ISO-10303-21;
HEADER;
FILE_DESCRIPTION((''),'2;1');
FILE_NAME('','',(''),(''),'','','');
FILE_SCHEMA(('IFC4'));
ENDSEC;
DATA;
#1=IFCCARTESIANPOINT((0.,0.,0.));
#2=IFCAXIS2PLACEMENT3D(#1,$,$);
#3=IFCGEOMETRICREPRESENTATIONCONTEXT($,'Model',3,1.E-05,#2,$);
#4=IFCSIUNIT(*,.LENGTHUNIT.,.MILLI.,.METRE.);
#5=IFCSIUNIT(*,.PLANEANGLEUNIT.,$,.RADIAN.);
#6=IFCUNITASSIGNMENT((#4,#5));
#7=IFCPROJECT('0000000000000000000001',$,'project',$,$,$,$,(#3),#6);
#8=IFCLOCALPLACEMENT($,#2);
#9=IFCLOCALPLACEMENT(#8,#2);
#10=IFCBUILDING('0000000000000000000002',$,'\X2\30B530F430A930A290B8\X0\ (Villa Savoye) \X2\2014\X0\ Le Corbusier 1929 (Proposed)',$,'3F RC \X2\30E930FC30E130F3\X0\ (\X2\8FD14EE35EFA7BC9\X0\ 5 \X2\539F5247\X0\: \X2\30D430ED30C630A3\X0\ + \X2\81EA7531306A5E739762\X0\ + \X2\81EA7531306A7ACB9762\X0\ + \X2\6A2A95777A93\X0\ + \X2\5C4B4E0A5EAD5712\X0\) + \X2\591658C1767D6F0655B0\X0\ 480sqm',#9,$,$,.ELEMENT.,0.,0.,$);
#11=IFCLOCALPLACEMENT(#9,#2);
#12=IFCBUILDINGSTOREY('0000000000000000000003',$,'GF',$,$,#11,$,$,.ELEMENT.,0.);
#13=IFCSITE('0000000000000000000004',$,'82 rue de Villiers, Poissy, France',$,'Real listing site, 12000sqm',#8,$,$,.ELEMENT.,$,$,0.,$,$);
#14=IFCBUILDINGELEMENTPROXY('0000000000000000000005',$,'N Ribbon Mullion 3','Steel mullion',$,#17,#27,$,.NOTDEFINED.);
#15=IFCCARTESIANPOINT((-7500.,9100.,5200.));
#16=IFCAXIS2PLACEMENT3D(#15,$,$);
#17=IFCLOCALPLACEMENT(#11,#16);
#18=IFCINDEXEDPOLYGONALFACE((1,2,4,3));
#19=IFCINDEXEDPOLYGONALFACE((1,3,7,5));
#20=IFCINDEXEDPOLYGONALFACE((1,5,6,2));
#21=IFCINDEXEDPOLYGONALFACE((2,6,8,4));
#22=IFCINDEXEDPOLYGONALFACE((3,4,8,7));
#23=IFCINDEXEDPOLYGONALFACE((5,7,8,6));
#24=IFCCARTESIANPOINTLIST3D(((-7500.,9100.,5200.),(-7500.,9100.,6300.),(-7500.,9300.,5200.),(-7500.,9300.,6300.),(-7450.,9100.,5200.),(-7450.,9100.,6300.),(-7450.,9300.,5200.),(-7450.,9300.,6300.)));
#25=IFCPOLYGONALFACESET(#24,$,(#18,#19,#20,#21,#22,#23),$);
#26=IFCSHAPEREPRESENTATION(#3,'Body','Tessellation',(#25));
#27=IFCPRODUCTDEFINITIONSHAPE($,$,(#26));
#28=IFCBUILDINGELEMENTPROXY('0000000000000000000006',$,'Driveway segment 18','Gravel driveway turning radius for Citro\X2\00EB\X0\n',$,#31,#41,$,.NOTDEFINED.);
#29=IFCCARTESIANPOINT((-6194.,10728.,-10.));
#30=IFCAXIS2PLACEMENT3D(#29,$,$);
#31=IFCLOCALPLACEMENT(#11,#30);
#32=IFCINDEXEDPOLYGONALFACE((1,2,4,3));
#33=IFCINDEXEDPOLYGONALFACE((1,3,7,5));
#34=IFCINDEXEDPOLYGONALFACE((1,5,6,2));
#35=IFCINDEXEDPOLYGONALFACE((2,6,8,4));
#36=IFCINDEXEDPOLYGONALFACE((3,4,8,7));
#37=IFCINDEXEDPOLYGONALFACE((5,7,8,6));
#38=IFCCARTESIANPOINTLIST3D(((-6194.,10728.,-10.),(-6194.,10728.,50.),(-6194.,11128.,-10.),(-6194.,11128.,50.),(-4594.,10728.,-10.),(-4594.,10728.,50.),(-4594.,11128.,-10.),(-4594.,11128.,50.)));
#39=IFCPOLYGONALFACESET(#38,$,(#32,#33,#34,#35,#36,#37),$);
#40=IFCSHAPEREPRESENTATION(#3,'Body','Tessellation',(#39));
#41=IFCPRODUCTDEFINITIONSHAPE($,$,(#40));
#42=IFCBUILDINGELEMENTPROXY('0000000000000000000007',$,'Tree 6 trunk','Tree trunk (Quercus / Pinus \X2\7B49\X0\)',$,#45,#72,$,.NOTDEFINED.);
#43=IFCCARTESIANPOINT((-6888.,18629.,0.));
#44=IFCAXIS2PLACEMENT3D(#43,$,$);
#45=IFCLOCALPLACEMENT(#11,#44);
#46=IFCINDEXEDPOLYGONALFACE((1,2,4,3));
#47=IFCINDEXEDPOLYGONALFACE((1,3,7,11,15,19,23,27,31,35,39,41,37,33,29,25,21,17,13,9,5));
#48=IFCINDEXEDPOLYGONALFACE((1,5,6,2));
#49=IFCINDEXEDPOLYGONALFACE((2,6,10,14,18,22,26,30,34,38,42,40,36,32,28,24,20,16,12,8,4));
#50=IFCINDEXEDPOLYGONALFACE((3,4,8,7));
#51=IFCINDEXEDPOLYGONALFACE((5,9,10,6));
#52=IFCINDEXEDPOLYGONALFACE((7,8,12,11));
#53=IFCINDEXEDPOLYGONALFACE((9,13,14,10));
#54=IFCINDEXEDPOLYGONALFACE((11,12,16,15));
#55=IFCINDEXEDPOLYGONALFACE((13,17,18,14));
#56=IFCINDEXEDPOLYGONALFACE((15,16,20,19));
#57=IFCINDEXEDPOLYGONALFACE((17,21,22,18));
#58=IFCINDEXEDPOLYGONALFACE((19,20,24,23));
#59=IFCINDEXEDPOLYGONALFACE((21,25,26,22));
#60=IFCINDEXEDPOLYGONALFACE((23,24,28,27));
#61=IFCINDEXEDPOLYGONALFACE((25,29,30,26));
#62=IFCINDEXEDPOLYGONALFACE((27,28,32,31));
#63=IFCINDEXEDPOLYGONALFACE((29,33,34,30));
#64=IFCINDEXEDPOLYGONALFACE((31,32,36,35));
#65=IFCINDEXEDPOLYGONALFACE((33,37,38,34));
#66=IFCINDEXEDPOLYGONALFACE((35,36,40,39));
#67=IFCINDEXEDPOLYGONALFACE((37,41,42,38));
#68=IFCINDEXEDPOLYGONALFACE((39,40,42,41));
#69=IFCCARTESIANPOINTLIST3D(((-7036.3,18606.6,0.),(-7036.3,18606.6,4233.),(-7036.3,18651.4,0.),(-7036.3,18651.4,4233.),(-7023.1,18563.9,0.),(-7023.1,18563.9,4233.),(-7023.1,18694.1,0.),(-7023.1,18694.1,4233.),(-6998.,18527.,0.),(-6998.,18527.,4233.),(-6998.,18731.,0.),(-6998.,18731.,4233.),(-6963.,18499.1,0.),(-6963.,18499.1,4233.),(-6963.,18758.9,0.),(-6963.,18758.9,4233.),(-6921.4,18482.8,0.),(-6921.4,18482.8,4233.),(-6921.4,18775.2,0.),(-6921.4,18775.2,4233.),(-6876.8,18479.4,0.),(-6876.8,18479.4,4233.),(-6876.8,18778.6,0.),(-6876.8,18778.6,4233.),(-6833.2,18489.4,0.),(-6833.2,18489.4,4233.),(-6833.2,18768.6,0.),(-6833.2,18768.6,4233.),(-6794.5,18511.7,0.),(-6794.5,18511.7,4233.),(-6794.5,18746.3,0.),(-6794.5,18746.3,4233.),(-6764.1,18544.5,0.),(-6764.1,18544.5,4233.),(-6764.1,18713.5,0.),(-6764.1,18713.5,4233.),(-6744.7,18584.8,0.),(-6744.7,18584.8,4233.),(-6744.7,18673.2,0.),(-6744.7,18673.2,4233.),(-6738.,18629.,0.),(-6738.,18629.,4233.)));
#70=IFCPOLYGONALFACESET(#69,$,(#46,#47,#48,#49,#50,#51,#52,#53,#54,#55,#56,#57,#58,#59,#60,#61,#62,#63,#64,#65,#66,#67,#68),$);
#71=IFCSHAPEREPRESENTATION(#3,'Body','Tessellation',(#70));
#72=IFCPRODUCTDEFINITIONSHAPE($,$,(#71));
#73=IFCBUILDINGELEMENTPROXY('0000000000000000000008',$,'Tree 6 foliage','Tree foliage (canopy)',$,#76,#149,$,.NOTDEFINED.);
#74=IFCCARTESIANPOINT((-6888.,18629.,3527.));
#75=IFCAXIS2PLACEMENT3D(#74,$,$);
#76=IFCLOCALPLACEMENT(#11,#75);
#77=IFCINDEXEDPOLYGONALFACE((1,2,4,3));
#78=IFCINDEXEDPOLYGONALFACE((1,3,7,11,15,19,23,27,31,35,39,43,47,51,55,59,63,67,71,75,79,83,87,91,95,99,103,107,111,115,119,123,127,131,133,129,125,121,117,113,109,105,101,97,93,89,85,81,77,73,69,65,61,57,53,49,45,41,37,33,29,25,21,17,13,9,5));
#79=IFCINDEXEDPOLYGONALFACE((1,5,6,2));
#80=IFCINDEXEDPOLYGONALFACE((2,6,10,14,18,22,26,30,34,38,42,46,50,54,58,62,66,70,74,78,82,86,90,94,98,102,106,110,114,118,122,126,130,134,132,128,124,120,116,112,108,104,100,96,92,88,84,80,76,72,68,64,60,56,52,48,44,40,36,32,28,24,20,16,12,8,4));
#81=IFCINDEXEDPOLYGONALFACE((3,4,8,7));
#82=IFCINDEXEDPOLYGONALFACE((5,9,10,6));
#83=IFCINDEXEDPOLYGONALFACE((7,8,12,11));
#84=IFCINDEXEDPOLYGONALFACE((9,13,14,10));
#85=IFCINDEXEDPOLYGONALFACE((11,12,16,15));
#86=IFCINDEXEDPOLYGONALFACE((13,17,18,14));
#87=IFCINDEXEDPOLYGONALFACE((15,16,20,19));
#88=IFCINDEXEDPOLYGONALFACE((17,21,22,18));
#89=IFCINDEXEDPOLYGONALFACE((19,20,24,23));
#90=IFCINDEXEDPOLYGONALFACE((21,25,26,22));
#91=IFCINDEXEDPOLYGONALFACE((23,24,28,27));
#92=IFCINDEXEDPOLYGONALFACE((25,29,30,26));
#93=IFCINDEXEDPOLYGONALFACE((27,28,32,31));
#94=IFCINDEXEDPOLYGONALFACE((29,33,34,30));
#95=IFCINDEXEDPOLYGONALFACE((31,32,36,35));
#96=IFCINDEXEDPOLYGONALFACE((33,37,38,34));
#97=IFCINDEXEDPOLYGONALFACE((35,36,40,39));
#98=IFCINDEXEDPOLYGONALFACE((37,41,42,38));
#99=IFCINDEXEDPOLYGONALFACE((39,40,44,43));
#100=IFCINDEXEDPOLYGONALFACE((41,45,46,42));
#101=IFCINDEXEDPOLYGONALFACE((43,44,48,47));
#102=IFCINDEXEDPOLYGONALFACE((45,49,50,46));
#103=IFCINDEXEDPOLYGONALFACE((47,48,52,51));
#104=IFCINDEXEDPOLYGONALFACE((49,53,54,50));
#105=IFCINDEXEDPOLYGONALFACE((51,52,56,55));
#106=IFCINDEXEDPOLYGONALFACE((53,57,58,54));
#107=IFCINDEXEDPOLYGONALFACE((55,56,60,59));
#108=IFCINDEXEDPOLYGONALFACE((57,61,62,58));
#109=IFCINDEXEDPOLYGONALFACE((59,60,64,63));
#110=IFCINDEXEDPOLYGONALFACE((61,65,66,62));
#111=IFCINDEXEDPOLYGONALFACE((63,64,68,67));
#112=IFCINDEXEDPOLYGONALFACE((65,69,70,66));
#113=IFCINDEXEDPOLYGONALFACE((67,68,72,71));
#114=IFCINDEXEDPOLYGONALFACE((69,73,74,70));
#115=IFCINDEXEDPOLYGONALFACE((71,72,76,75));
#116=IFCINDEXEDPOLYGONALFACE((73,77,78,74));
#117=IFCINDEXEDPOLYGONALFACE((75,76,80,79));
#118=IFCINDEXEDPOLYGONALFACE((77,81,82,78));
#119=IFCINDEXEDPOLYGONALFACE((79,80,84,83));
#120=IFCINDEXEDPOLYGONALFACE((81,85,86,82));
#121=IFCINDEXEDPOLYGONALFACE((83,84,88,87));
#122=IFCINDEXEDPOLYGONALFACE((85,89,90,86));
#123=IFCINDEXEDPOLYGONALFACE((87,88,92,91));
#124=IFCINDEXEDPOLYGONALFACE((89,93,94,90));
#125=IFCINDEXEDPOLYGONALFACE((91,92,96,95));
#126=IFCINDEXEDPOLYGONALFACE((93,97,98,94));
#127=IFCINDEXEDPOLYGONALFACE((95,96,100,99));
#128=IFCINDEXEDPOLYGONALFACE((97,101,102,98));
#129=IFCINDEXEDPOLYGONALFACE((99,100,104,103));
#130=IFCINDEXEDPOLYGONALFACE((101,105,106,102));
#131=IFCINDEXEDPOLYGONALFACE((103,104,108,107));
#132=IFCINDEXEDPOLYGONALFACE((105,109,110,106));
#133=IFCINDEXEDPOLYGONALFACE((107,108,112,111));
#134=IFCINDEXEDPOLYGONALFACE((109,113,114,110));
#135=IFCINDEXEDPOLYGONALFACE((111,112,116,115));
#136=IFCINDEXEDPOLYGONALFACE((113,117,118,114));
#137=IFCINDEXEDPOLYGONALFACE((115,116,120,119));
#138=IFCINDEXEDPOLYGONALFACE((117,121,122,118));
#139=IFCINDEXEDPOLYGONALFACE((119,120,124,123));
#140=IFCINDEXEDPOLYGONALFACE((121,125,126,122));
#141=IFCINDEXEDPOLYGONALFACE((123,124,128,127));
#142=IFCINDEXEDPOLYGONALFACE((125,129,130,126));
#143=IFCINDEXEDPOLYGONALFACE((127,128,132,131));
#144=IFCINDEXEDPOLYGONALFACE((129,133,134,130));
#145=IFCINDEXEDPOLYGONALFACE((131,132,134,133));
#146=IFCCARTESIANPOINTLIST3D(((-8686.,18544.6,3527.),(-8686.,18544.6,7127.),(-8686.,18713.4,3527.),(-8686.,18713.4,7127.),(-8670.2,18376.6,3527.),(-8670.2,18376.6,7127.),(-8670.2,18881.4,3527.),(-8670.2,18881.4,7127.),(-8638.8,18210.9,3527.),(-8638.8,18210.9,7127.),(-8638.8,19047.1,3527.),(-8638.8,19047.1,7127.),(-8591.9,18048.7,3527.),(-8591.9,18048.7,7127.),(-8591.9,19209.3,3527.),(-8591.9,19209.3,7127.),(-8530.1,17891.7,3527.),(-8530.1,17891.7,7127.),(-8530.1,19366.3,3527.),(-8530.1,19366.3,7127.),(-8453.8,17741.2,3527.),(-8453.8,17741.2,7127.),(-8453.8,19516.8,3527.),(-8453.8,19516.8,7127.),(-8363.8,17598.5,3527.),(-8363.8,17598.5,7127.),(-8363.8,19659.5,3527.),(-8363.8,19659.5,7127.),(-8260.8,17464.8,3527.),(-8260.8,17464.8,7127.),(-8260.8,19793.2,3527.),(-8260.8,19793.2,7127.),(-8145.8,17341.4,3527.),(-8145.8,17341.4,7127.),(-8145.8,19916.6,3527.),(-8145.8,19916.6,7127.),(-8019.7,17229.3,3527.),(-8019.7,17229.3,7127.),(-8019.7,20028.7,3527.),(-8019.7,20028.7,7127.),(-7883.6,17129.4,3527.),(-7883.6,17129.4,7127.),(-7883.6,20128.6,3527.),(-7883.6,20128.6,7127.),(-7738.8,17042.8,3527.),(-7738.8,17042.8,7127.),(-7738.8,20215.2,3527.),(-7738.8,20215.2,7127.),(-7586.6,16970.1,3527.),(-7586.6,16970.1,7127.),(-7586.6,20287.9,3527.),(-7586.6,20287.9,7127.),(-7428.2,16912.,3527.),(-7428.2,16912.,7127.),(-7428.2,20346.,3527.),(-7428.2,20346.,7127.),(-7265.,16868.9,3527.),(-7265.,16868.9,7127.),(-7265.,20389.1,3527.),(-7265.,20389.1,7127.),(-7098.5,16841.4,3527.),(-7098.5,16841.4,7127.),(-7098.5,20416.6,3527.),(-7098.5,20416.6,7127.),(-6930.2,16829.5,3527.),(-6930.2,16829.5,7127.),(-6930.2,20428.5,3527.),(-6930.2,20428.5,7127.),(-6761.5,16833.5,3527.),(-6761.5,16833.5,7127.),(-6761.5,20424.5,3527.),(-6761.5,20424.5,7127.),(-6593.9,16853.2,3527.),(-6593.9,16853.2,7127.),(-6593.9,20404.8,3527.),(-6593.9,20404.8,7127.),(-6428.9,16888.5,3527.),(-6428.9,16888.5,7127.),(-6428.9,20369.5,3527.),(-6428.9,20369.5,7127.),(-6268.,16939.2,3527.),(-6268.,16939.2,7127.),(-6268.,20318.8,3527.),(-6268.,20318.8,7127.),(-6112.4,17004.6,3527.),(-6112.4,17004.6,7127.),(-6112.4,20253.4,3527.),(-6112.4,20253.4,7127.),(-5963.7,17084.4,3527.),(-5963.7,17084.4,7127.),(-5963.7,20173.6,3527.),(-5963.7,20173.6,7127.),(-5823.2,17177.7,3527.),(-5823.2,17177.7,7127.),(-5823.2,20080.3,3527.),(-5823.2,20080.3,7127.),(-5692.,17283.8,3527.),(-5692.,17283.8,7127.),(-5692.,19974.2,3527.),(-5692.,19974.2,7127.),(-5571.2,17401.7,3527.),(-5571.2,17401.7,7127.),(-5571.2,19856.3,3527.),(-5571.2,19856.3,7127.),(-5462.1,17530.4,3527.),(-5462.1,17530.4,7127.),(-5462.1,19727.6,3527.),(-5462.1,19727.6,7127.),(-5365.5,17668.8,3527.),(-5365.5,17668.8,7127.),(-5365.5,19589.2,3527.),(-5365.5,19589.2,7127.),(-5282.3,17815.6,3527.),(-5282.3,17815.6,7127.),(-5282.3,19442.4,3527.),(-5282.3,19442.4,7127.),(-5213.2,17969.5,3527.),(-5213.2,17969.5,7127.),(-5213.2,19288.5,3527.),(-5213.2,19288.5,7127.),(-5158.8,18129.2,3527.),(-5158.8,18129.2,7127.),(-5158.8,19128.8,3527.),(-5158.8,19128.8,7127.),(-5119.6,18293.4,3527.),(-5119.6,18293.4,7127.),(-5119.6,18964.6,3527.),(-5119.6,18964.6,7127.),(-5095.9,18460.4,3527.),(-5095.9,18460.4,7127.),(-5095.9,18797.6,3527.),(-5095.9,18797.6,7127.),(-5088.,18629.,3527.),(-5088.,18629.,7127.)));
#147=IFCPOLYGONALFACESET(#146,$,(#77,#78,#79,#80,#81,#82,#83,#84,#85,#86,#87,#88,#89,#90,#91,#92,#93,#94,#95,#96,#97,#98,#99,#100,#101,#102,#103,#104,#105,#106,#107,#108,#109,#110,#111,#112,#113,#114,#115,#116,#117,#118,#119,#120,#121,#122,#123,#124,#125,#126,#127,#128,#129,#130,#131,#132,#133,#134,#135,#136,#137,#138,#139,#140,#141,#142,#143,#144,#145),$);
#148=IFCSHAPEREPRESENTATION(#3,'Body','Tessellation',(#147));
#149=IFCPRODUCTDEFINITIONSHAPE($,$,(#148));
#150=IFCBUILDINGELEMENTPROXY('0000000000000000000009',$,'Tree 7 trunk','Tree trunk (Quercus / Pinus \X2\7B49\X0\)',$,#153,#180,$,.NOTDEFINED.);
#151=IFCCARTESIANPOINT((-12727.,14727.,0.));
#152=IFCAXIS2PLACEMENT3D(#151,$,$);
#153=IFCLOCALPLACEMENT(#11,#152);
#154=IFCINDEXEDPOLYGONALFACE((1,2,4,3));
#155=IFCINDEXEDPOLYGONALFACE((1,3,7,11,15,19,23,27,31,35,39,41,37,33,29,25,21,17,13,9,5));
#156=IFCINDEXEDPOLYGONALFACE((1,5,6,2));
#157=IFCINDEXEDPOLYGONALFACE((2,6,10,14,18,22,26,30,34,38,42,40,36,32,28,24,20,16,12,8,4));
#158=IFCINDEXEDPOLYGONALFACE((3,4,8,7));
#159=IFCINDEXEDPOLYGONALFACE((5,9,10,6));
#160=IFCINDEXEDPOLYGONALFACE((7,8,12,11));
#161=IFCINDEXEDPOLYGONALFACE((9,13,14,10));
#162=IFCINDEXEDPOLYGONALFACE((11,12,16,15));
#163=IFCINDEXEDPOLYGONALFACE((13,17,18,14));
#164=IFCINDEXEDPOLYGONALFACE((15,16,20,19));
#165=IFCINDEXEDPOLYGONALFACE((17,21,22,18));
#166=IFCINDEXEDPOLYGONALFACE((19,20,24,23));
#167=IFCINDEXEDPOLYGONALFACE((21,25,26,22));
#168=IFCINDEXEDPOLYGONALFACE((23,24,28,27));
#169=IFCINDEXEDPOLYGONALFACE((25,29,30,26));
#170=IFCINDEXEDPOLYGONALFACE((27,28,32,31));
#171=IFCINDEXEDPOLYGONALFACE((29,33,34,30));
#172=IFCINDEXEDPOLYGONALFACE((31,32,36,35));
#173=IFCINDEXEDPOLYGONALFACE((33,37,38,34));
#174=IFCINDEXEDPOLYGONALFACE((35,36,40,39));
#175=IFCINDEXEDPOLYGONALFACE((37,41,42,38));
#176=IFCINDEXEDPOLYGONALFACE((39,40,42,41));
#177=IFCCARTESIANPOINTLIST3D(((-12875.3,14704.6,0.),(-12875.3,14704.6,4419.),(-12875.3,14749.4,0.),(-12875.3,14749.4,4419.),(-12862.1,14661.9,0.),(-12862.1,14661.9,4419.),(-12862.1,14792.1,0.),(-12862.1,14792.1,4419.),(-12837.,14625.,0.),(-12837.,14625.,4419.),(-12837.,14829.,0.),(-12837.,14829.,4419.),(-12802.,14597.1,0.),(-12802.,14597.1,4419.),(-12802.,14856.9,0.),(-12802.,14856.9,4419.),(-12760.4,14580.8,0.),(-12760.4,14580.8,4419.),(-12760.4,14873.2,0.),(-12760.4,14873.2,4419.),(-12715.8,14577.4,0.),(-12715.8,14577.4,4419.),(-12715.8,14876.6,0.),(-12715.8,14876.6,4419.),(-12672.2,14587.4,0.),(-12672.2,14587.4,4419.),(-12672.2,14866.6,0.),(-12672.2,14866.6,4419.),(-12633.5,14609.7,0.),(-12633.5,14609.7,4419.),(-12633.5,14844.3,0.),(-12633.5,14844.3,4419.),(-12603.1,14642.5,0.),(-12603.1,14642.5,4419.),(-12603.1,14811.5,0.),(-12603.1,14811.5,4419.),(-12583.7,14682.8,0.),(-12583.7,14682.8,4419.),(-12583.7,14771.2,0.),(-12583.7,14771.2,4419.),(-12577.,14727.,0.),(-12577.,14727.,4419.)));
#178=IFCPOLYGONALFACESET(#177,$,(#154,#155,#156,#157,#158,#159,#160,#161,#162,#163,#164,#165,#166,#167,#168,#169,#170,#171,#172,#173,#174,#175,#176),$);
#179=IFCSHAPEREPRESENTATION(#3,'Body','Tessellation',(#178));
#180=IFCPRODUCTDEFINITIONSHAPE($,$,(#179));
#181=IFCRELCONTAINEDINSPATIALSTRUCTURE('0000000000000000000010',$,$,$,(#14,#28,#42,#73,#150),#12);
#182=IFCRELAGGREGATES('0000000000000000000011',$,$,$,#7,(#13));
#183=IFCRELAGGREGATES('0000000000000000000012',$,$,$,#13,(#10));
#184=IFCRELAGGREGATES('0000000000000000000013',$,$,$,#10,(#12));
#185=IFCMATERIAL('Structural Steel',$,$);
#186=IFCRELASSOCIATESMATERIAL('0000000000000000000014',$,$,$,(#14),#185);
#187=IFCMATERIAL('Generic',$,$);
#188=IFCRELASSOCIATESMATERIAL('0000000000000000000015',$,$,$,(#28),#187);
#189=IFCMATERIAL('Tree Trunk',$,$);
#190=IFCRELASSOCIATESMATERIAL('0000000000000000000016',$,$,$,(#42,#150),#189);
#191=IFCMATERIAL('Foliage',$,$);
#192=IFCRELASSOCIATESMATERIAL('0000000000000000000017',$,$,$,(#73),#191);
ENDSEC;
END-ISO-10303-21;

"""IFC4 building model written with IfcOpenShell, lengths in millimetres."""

from ifc_helpers import new_model, si_unit, frame, frame_2d, origin, origin_2d, place, context, project, spatial, rectangle, circle, extrude, material, element, save


model = new_model("IFC4")

# Units and contexts
model_context = context("Model", 3, precision=1e-05, world=origin())
ifc_project = project(units=[si_unit("LENGTHUNIT", "METRE", prefix="MILLI"), si_unit("PLANEANGLEUNIT", "RADIAN")], contexts=[model_context])

# Site, building, storey
site_placement = place(None, origin())
site = spatial("IfcSite", under=ifc_project, at=site_placement, Name="82 rue de Villiers, Poissy, France", ObjectType="Real listing site, 12000sqm", CompositionType="ELEMENT", RefElevation=0.0)
building_placement = place(site_placement, origin())
building = spatial("IfcBuilding", under=site, at=building_placement, Name="サヴォア邸 (Villa Savoye) — Le Corbusier 1929 (Proposed)", ObjectType="3F RC ラーメン (近代建築 5 原則: ピロティ + 自由な平面 + 自由な立面 + 横長窓 + 屋上庭園) + 外壁白漆喰 480sqm", CompositionType="ELEMENT", ElevationOfRefHeight=0.0, ElevationOfTerrain=0.0)
storey_placement = place(building_placement, origin())
storey = spatial("IfcBuildingStorey", under=building, at=storey_placement, Name="GF", CompositionType="ELEMENT", Elevation=0.0)

# Shared definitions
ifc_material_1 = material(Name="Generic")

# Building element proxies
ifc_material_2 = material(Name="Structural Steel")
proxy_1_placement = place(storey_placement, frame((-7500.0, 9100.0, 5200.0)))
element("IfcBuildingElementProxy", 1, at=proxy_1_placement, inside=storey, material=ifc_material_2, Name="N Ribbon Mullion 3", Description="Steel mullion", PredefinedType="NOTDEFINED", context=model_context, shape_type="SweptSolid", body=[
    extrude(rectangle(XDim=50.0, YDim=200.0, at=frame_2d((25.0, 100.0))), frame((-7500.0, 9100.0, 5200.0)), (0.0, 0.0, 1.0), 1100.0),
])
proxy_2_placement = place(storey_placement, frame((-6194.0, 10728.0, -10.0)))
element("IfcBuildingElementProxy", 2, at=proxy_2_placement, inside=storey, material=ifc_material_1, Name="Driveway segment 18", Description="Gravel driveway turning radius for Citroën", PredefinedType="NOTDEFINED", context=model_context, shape_type="SweptSolid", body=[
    extrude(rectangle(XDim=1600.0, YDim=400.0, at=frame_2d((800.0, 200.0))), frame((-6194.0, 10728.0, -10.0)), (0.0, 0.0, 1.0), 60.0),
])
ifc_material_3 = material(Name="Tree Trunk")
proxy_3_placement = place(storey_placement, frame((-6888.0, 18629.0, 0.0)))
element("IfcBuildingElementProxy", 3, at=proxy_3_placement, inside=storey, material=ifc_material_3, Name="Tree 6 trunk", Description="Tree trunk (Quercus / Pinus 等)", PredefinedType="NOTDEFINED", context=model_context, shape_type="SweptSolid", body=[
    extrude(circle(Radius=150.0, at=origin_2d()), frame((-6888.0, 18629.0, 0.0)), (0.0, 0.0, 1.0), 4233.0),
])
ifc_material_4 = material(Name="Foliage")
proxy_4_placement = place(storey_placement, frame((-6888.0, 18629.0, 3527.0)))
element("IfcBuildingElementProxy", 4, at=proxy_4_placement, inside=storey, material=ifc_material_4, Name="Tree 6 foliage", Description="Tree foliage (canopy)", PredefinedType="NOTDEFINED", context=model_context, shape_type="SweptSolid", body=[
    extrude(circle(Radius=1800.0, at=origin_2d()), frame((-6888.0, 18629.0, 3527.0)), (0.0, 0.0, 1.0), 3600.0),
])
proxy_5_placement = place(storey_placement, frame((-12727.0, 14727.0, 0.0)))
element("IfcBuildingElementProxy", 5, at=proxy_5_placement, inside=storey, material=ifc_material_3, Name="Tree 7 trunk", Description="Tree trunk (Quercus / Pinus 等)", PredefinedType="NOTDEFINED", context=model_context, shape_type="SweptSolid", body=[
    extrude(circle(Radius=150.0, at=origin_2d()), frame((-12727.0, 14727.0, 0.0)), (0.0, 0.0, 1.0), 4419.0),
])

save(model, "model.ifc")
